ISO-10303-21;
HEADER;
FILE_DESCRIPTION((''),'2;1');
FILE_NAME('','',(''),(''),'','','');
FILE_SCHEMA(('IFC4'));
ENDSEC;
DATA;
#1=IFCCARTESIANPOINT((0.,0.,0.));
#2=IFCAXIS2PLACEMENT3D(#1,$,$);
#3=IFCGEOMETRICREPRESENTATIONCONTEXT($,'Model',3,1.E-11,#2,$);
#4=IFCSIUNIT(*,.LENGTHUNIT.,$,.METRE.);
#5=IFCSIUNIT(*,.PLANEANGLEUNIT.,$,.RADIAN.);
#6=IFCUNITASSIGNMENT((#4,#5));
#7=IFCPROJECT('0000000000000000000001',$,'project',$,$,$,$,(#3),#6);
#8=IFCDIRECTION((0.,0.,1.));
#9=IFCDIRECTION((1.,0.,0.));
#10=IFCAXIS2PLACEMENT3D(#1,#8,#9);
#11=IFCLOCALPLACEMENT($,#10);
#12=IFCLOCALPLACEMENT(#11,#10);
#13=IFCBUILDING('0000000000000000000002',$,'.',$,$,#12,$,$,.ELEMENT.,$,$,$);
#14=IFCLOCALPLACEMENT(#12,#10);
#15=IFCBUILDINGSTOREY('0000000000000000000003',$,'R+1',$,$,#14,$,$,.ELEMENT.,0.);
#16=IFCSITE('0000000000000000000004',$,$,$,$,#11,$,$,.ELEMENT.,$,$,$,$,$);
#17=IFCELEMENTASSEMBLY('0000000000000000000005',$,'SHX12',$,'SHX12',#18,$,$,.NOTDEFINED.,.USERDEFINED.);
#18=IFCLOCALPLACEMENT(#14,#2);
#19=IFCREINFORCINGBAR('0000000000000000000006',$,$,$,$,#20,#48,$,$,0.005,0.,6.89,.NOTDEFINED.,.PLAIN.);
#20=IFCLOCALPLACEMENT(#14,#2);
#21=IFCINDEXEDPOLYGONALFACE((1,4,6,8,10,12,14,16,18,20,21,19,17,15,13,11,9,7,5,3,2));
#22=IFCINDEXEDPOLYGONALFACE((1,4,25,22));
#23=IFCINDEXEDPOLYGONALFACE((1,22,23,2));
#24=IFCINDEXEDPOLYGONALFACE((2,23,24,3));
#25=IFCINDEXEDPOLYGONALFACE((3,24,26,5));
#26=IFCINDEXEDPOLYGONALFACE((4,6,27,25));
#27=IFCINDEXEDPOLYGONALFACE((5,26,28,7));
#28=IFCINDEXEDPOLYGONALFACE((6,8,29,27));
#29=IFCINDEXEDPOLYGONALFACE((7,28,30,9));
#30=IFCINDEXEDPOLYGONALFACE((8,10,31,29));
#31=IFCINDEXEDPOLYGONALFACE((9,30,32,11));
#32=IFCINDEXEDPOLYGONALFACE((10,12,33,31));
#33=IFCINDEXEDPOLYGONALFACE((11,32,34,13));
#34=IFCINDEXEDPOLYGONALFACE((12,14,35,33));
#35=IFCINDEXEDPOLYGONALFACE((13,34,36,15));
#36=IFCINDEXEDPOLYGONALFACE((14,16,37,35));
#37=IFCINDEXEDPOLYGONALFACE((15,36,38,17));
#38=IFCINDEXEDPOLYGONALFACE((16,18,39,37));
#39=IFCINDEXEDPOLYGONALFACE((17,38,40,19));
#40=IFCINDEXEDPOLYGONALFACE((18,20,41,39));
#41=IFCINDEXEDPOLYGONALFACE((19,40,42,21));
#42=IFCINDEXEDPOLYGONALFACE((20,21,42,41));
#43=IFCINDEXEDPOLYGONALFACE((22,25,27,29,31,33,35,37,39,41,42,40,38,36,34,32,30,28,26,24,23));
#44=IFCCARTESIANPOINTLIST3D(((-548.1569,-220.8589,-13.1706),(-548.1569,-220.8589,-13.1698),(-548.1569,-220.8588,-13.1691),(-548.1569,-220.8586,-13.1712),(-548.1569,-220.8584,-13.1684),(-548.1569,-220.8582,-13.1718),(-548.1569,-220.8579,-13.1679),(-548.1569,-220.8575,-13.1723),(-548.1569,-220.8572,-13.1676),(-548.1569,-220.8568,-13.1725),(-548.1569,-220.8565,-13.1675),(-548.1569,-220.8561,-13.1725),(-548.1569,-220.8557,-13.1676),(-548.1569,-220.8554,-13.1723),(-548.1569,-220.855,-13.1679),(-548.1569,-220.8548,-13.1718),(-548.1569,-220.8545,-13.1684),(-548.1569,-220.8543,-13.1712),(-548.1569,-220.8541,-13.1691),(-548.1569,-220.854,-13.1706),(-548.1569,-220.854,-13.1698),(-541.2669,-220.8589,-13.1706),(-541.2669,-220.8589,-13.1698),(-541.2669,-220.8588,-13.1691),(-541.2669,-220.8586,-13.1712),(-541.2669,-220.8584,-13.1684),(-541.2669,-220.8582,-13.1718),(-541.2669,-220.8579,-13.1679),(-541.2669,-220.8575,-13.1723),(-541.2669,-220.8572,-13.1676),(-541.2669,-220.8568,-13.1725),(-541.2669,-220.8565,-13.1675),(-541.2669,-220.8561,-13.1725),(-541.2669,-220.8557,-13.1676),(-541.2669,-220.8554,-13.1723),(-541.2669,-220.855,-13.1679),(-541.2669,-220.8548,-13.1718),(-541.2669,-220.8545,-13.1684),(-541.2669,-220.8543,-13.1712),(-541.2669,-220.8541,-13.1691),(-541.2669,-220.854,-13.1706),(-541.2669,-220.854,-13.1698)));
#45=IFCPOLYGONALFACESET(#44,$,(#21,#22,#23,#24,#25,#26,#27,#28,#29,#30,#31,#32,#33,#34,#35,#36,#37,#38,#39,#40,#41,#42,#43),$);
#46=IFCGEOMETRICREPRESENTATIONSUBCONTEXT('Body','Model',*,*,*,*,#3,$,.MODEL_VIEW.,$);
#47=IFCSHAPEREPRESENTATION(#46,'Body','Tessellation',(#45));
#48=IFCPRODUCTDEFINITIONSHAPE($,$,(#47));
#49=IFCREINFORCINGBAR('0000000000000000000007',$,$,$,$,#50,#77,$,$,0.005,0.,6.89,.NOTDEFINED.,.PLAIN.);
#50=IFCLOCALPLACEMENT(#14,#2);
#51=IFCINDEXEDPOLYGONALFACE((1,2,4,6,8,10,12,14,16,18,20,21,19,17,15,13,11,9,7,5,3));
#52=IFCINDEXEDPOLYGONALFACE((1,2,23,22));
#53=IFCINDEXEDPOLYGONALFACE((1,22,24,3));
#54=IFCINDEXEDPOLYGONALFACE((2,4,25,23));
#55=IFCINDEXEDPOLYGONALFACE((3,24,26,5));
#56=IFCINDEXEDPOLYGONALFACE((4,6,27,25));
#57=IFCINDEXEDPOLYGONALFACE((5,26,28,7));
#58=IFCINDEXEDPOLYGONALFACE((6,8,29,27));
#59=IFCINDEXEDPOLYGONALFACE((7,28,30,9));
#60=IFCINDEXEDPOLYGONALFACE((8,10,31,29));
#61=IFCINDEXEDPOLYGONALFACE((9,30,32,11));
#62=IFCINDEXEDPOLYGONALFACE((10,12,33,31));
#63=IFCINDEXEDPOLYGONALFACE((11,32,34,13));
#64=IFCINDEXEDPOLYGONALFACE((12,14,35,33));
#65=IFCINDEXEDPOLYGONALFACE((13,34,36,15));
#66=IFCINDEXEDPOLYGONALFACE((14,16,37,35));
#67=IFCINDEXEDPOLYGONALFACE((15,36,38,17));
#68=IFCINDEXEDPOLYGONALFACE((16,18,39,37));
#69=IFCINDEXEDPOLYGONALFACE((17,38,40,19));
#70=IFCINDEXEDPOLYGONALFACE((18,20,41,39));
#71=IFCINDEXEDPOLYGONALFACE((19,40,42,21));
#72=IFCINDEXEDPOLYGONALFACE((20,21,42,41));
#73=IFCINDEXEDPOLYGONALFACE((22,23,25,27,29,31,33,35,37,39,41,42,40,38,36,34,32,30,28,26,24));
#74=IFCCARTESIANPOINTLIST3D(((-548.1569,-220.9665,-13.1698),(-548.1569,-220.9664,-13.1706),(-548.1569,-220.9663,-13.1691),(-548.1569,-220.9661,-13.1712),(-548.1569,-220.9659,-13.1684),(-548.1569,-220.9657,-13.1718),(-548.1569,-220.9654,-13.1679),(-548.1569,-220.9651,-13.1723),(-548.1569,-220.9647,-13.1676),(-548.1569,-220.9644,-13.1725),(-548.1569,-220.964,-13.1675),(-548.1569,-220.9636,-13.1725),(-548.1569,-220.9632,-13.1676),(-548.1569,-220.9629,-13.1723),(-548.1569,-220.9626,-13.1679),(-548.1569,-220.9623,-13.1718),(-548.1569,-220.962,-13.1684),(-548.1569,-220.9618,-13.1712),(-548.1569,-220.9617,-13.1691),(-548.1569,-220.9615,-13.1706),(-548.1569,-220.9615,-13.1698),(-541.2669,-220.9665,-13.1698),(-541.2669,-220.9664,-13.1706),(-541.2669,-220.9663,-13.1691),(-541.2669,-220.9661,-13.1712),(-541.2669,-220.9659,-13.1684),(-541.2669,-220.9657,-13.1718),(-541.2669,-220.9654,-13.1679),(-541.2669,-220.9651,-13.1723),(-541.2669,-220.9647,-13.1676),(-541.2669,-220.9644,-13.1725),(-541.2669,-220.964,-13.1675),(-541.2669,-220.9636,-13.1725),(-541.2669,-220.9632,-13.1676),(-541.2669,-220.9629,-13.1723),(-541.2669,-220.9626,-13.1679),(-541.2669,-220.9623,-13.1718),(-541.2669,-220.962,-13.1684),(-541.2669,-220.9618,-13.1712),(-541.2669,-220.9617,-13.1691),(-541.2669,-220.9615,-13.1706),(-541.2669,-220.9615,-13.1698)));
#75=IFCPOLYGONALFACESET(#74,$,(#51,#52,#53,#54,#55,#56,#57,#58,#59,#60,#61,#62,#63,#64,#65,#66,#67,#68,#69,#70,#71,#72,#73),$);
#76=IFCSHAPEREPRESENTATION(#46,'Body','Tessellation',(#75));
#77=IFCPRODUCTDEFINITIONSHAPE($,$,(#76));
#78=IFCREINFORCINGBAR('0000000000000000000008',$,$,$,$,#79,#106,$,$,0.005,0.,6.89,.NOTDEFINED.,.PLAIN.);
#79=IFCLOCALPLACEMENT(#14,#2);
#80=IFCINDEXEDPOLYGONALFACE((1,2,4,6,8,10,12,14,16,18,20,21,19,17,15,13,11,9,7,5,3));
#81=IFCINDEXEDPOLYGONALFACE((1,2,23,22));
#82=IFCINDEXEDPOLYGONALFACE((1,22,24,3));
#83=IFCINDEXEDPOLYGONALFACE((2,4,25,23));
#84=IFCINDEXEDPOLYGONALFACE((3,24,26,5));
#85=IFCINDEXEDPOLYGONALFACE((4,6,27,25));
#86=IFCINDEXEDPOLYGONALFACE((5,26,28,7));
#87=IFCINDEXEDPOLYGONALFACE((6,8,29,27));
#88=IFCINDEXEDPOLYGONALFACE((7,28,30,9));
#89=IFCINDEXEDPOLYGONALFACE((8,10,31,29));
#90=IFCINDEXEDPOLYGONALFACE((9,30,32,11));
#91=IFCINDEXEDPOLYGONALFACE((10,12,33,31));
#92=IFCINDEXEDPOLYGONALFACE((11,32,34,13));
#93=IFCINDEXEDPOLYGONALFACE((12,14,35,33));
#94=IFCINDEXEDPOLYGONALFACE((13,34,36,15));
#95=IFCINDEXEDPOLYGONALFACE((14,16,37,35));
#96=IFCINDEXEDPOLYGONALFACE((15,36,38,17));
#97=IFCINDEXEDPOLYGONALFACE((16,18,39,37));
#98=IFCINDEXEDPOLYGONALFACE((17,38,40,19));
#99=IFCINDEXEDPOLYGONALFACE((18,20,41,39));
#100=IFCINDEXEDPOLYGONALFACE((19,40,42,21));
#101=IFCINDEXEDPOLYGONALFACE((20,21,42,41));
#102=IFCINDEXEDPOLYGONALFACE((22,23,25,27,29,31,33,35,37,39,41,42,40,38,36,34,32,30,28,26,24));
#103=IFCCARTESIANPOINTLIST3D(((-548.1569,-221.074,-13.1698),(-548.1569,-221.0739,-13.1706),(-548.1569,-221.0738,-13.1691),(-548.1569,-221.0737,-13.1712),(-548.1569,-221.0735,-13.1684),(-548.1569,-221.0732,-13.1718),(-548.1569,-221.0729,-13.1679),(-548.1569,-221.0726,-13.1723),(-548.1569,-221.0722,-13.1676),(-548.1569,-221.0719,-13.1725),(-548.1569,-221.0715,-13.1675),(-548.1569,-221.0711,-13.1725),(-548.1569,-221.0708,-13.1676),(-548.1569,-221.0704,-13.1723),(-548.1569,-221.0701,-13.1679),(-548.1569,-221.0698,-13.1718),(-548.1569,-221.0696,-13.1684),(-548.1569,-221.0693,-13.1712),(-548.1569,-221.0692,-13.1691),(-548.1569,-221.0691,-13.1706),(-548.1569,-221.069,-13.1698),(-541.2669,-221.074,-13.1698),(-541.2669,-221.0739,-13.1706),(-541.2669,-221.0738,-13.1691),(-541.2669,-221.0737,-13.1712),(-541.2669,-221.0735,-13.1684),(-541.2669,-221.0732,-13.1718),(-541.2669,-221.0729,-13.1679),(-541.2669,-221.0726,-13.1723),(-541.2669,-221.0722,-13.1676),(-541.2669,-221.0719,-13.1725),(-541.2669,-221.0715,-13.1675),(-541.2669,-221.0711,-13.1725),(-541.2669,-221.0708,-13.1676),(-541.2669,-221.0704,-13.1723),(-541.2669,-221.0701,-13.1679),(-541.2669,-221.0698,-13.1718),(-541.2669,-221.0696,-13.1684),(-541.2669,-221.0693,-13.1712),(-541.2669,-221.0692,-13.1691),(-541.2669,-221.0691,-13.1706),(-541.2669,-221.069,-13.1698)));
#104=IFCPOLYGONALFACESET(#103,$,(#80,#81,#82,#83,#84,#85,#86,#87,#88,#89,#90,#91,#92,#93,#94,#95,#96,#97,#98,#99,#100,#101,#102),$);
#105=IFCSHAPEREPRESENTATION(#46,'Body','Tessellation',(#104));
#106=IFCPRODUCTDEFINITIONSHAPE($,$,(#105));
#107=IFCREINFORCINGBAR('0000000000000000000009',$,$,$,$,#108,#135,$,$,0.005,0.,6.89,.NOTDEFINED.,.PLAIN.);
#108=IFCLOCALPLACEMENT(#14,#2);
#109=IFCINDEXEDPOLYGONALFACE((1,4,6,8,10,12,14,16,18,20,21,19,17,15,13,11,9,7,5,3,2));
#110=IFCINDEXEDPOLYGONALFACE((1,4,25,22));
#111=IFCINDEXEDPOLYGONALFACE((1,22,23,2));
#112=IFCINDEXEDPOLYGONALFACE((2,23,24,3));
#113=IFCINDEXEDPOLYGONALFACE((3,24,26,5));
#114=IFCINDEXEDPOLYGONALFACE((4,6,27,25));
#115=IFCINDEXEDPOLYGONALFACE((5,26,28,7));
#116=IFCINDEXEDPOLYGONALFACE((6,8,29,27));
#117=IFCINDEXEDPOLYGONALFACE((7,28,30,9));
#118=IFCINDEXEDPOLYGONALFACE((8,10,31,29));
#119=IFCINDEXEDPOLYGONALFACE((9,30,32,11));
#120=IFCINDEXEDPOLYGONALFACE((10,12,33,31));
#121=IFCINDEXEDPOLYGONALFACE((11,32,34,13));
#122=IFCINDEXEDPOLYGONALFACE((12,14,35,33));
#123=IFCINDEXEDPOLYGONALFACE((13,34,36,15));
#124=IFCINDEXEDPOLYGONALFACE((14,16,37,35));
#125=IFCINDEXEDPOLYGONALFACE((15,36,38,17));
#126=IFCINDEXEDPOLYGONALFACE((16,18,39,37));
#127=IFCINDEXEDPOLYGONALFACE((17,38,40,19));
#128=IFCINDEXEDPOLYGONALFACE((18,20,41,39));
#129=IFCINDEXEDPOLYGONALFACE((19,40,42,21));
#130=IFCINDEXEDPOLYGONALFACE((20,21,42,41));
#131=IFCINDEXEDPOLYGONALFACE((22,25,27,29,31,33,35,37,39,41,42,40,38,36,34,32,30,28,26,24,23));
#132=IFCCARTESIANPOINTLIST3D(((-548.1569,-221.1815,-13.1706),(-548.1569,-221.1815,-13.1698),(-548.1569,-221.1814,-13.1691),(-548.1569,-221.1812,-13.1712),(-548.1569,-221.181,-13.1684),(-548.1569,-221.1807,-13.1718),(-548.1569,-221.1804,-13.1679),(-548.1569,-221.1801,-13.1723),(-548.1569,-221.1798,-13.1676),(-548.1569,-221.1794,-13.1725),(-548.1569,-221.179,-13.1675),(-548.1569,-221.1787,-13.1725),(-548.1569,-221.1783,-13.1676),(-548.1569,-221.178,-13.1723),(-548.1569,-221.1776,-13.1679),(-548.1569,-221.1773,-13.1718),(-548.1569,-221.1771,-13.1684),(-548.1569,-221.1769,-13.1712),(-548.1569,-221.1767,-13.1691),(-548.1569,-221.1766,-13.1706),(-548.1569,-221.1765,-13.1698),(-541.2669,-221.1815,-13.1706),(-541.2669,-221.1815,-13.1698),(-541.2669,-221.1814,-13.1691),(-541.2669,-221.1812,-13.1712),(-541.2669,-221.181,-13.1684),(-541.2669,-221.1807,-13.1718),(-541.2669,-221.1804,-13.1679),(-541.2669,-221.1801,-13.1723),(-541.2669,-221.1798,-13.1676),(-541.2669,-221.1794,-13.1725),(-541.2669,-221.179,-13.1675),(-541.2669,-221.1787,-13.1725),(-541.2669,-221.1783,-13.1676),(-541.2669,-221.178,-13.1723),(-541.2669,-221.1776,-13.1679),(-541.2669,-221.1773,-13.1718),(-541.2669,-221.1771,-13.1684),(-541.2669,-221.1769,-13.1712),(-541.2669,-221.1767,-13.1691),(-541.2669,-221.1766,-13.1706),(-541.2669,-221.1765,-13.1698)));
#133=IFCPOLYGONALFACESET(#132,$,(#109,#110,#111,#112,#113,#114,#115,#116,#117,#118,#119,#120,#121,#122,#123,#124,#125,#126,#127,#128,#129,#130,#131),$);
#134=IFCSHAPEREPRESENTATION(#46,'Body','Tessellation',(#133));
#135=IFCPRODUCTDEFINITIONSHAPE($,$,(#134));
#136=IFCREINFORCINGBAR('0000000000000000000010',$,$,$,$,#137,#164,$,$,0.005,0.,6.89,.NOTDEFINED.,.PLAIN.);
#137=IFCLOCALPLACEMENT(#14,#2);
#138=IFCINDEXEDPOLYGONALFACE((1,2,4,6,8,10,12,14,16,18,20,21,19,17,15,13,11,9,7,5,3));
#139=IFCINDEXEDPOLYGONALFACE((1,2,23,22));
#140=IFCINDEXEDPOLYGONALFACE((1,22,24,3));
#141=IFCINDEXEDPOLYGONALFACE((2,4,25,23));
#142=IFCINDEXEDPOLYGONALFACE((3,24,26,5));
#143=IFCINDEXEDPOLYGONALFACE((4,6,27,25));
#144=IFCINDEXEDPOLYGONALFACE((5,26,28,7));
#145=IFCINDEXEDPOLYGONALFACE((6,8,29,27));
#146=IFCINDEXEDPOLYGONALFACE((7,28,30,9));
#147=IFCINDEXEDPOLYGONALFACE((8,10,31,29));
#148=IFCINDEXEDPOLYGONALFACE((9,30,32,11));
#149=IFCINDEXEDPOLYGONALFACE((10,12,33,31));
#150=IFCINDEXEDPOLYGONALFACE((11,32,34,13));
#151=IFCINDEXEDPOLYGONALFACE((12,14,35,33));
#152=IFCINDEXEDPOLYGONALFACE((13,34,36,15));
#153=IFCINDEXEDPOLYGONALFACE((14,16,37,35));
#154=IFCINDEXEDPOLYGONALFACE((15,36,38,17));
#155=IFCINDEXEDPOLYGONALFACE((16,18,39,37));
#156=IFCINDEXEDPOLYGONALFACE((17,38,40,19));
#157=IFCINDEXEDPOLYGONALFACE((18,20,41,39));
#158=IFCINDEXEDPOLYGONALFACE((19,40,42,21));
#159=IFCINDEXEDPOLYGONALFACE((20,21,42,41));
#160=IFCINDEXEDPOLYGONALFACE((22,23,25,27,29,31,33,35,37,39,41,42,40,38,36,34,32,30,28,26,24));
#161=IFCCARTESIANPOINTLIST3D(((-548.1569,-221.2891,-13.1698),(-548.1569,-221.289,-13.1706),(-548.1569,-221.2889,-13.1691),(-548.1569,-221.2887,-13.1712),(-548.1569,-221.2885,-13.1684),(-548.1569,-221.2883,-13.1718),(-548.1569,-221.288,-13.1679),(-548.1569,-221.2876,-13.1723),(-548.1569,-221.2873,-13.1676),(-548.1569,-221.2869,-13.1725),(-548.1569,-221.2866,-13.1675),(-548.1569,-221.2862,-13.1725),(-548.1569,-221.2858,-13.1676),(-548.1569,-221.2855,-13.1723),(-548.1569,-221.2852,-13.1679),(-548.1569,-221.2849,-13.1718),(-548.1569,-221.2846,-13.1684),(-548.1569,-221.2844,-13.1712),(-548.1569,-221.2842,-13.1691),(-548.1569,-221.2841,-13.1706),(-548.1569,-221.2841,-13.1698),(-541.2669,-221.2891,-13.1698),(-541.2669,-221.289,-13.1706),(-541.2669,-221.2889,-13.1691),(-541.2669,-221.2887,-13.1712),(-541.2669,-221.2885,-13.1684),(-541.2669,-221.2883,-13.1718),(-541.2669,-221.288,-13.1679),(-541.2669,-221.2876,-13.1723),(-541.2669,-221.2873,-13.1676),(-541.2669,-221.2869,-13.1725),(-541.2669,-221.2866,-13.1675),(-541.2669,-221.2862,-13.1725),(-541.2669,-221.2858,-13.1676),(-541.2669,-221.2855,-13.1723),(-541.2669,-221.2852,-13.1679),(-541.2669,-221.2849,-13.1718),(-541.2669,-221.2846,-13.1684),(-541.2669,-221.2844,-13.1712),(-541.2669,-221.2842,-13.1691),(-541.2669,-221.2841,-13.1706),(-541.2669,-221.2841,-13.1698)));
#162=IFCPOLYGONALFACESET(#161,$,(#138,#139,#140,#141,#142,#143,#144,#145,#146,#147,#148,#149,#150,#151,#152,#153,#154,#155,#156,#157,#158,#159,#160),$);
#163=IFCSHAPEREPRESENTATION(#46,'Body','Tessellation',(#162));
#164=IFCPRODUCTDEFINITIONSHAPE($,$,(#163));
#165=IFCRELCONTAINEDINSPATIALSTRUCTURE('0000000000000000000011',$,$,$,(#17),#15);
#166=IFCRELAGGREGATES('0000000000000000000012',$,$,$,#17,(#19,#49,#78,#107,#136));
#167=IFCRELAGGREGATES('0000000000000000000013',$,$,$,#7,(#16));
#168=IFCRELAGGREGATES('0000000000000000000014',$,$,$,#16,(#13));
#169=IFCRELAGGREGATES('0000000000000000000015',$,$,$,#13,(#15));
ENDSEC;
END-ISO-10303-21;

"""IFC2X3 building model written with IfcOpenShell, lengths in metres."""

from ifc_helpers import new_model, entity, si_unit, origin, origin_with_axes, place, context, subcontext, project, spatial, shape, element, aggregate, save


model = new_model("IFC2X3")

# Units and contexts
model_context = context("Model", 3, precision=1e-11, world=origin())
body_context = subcontext(model_context, "Body", "Model", "MODEL_VIEW")
ifc_project = project(units=[si_unit("LENGTHUNIT", "METRE"), si_unit("PLANEANGLEUNIT", "RADIAN")], contexts=[model_context])

# Site, building, storey
site_placement = place(None, origin_with_axes())
site = spatial("IfcSite", under=ifc_project, at=site_placement, CompositionType="ELEMENT")
building_placement = place(site_placement, origin_with_axes())
building = spatial("IfcBuilding", under=site, at=building_placement, Name=".", CompositionType="ELEMENT")
storey_placement = place(building_placement, origin_with_axes())
storey = spatial("IfcBuildingStorey", under=building, at=storey_placement, Name="R+1", CompositionType="ELEMENT", Elevation=0.0)

# Element assembly, reinforcing bars
assembly_1_placement = place(storey_placement, origin_with_axes())
assembly_1 = element("IfcElementAssembly", 1, at=assembly_1_placement, inside=storey, Name="SHX12", ObjectType="SHX12", AssemblyPlace="NOTDEFINED", PredefinedType="USERDEFINED")
reinforcing_bar_1_placement = place(assembly_1_placement, origin_with_axes())
reinforcing_bar_1 = element("IfcReinforcingBar", 2, at=reinforcing_bar_1_placement, BarLength=6.89, BarRole="NOTDEFINED", BarSurface="PLAIN", CrossSectionArea=0.0, NominalDiameter=0.005, shapes=[
    shape(body_context, "Body", "AdvancedSweptSolid", [entity("IfcSweptDiskSolid", entity("IfcPolyline", [entity("IfcCartesianPoint", [541.2669, 220.8565, 13.17]), entity("IfcCartesianPoint", [548.1569, 220.8565, 13.17])]), 0.0025, None, 0.0, 6.89)]),
    shape(body_context, "Body", "AdvancedSweptSolid", [entity("IfcSweptDiskSolid", entity("IfcPolyline", [entity("IfcCartesianPoint", [541.2669, 220.8565, 13.17]), entity("IfcCartesianPoint", [548.1569, 220.8565, 13.17])]), 0.0025, None, 0.0, 6.89)]),
])
reinforcing_bar_2_placement = place(assembly_1_placement, origin_with_axes())
reinforcing_bar_2 = element("IfcReinforcingBar", 3, at=reinforcing_bar_2_placement, BarLength=6.89, BarRole="NOTDEFINED", BarSurface="PLAIN", CrossSectionArea=0.0, NominalDiameter=0.005, shapes=[
    shape(body_context, "Body", "AdvancedSweptSolid", [entity("IfcSweptDiskSolid", entity("IfcPolyline", [entity("IfcCartesianPoint", [541.2669, 220.964, 13.17]), entity("IfcCartesianPoint", [548.1569, 220.964, 13.17])]), 0.0025, None, 0.0, 6.89)]),
    shape(body_context, "Body", "AdvancedSweptSolid", [entity("IfcSweptDiskSolid", entity("IfcPolyline", [entity("IfcCartesianPoint", [541.2669, 220.964, 13.17]), entity("IfcCartesianPoint", [548.1569, 220.964, 13.17])]), 0.0025, None, 0.0, 6.89)]),
])
reinforcing_bar_3_placement = place(assembly_1_placement, origin_with_axes())
reinforcing_bar_3 = element("IfcReinforcingBar", 4, at=reinforcing_bar_3_placement, BarLength=6.89, BarRole="NOTDEFINED", BarSurface="PLAIN", CrossSectionArea=0.0, NominalDiameter=0.005, shapes=[
    shape(body_context, "Body", "AdvancedSweptSolid", [entity("IfcSweptDiskSolid", entity("IfcPolyline", [entity("IfcCartesianPoint", [541.2669, 221.0715, 13.17]), entity("IfcCartesianPoint", [548.1569, 221.0715, 13.17])]), 0.0025, None, 0.0, 6.89)]),
    shape(body_context, "Body", "AdvancedSweptSolid", [entity("IfcSweptDiskSolid", entity("IfcPolyline", [entity("IfcCartesianPoint", [541.2669, 221.0715, 13.17]), entity("IfcCartesianPoint", [548.1569, 221.0715, 13.17])]), 0.0025, None, 0.0, 6.89)]),
])
reinforcing_bar_4_placement = place(assembly_1_placement, origin_with_axes())
reinforcing_bar_4 = element("IfcReinforcingBar", 5, at=reinforcing_bar_4_placement, BarLength=6.89, BarRole="NOTDEFINED", BarSurface="PLAIN", CrossSectionArea=0.0, NominalDiameter=0.005, shapes=[
    shape(body_context, "Body", "AdvancedSweptSolid", [entity("IfcSweptDiskSolid", entity("IfcPolyline", [entity("IfcCartesianPoint", [541.2669, 221.179, 13.17]), entity("IfcCartesianPoint", [548.1569, 221.179, 13.17])]), 0.0025, None, 0.0, 6.89)]),
    shape(body_context, "Body", "AdvancedSweptSolid", [entity("IfcSweptDiskSolid", entity("IfcPolyline", [entity("IfcCartesianPoint", [541.2669, 221.179, 13.17]), entity("IfcCartesianPoint", [548.1569, 221.179, 13.17])]), 0.0025, None, 0.0, 6.89)]),
])
reinforcing_bar_5_placement = place(assembly_1_placement, origin_with_axes())
reinforcing_bar_5 = element("IfcReinforcingBar", 6, at=reinforcing_bar_5_placement, BarLength=6.89, BarRole="NOTDEFINED", BarSurface="PLAIN", CrossSectionArea=0.0, NominalDiameter=0.005, shapes=[
    shape(body_context, "Body", "AdvancedSweptSolid", [entity("IfcSweptDiskSolid", entity("IfcPolyline", [entity("IfcCartesianPoint", [541.2669, 221.2866, 13.17]), entity("IfcCartesianPoint", [548.1569, 221.2866, 13.17])]), 0.0025, None, 0.0, 6.89)]),
    shape(body_context, "Body", "AdvancedSweptSolid", [entity("IfcSweptDiskSolid", entity("IfcPolyline", [entity("IfcCartesianPoint", [541.2669, 221.2866, 13.17]), entity("IfcCartesianPoint", [548.1569, 221.2866, 13.17])]), 0.0025, None, 0.0, 6.89)]),
])
aggregate(assembly_1, [reinforcing_bar_1, reinforcing_bar_2, reinforcing_bar_3, reinforcing_bar_4, reinforcing_bar_5])

save(model, "model.ifc")
